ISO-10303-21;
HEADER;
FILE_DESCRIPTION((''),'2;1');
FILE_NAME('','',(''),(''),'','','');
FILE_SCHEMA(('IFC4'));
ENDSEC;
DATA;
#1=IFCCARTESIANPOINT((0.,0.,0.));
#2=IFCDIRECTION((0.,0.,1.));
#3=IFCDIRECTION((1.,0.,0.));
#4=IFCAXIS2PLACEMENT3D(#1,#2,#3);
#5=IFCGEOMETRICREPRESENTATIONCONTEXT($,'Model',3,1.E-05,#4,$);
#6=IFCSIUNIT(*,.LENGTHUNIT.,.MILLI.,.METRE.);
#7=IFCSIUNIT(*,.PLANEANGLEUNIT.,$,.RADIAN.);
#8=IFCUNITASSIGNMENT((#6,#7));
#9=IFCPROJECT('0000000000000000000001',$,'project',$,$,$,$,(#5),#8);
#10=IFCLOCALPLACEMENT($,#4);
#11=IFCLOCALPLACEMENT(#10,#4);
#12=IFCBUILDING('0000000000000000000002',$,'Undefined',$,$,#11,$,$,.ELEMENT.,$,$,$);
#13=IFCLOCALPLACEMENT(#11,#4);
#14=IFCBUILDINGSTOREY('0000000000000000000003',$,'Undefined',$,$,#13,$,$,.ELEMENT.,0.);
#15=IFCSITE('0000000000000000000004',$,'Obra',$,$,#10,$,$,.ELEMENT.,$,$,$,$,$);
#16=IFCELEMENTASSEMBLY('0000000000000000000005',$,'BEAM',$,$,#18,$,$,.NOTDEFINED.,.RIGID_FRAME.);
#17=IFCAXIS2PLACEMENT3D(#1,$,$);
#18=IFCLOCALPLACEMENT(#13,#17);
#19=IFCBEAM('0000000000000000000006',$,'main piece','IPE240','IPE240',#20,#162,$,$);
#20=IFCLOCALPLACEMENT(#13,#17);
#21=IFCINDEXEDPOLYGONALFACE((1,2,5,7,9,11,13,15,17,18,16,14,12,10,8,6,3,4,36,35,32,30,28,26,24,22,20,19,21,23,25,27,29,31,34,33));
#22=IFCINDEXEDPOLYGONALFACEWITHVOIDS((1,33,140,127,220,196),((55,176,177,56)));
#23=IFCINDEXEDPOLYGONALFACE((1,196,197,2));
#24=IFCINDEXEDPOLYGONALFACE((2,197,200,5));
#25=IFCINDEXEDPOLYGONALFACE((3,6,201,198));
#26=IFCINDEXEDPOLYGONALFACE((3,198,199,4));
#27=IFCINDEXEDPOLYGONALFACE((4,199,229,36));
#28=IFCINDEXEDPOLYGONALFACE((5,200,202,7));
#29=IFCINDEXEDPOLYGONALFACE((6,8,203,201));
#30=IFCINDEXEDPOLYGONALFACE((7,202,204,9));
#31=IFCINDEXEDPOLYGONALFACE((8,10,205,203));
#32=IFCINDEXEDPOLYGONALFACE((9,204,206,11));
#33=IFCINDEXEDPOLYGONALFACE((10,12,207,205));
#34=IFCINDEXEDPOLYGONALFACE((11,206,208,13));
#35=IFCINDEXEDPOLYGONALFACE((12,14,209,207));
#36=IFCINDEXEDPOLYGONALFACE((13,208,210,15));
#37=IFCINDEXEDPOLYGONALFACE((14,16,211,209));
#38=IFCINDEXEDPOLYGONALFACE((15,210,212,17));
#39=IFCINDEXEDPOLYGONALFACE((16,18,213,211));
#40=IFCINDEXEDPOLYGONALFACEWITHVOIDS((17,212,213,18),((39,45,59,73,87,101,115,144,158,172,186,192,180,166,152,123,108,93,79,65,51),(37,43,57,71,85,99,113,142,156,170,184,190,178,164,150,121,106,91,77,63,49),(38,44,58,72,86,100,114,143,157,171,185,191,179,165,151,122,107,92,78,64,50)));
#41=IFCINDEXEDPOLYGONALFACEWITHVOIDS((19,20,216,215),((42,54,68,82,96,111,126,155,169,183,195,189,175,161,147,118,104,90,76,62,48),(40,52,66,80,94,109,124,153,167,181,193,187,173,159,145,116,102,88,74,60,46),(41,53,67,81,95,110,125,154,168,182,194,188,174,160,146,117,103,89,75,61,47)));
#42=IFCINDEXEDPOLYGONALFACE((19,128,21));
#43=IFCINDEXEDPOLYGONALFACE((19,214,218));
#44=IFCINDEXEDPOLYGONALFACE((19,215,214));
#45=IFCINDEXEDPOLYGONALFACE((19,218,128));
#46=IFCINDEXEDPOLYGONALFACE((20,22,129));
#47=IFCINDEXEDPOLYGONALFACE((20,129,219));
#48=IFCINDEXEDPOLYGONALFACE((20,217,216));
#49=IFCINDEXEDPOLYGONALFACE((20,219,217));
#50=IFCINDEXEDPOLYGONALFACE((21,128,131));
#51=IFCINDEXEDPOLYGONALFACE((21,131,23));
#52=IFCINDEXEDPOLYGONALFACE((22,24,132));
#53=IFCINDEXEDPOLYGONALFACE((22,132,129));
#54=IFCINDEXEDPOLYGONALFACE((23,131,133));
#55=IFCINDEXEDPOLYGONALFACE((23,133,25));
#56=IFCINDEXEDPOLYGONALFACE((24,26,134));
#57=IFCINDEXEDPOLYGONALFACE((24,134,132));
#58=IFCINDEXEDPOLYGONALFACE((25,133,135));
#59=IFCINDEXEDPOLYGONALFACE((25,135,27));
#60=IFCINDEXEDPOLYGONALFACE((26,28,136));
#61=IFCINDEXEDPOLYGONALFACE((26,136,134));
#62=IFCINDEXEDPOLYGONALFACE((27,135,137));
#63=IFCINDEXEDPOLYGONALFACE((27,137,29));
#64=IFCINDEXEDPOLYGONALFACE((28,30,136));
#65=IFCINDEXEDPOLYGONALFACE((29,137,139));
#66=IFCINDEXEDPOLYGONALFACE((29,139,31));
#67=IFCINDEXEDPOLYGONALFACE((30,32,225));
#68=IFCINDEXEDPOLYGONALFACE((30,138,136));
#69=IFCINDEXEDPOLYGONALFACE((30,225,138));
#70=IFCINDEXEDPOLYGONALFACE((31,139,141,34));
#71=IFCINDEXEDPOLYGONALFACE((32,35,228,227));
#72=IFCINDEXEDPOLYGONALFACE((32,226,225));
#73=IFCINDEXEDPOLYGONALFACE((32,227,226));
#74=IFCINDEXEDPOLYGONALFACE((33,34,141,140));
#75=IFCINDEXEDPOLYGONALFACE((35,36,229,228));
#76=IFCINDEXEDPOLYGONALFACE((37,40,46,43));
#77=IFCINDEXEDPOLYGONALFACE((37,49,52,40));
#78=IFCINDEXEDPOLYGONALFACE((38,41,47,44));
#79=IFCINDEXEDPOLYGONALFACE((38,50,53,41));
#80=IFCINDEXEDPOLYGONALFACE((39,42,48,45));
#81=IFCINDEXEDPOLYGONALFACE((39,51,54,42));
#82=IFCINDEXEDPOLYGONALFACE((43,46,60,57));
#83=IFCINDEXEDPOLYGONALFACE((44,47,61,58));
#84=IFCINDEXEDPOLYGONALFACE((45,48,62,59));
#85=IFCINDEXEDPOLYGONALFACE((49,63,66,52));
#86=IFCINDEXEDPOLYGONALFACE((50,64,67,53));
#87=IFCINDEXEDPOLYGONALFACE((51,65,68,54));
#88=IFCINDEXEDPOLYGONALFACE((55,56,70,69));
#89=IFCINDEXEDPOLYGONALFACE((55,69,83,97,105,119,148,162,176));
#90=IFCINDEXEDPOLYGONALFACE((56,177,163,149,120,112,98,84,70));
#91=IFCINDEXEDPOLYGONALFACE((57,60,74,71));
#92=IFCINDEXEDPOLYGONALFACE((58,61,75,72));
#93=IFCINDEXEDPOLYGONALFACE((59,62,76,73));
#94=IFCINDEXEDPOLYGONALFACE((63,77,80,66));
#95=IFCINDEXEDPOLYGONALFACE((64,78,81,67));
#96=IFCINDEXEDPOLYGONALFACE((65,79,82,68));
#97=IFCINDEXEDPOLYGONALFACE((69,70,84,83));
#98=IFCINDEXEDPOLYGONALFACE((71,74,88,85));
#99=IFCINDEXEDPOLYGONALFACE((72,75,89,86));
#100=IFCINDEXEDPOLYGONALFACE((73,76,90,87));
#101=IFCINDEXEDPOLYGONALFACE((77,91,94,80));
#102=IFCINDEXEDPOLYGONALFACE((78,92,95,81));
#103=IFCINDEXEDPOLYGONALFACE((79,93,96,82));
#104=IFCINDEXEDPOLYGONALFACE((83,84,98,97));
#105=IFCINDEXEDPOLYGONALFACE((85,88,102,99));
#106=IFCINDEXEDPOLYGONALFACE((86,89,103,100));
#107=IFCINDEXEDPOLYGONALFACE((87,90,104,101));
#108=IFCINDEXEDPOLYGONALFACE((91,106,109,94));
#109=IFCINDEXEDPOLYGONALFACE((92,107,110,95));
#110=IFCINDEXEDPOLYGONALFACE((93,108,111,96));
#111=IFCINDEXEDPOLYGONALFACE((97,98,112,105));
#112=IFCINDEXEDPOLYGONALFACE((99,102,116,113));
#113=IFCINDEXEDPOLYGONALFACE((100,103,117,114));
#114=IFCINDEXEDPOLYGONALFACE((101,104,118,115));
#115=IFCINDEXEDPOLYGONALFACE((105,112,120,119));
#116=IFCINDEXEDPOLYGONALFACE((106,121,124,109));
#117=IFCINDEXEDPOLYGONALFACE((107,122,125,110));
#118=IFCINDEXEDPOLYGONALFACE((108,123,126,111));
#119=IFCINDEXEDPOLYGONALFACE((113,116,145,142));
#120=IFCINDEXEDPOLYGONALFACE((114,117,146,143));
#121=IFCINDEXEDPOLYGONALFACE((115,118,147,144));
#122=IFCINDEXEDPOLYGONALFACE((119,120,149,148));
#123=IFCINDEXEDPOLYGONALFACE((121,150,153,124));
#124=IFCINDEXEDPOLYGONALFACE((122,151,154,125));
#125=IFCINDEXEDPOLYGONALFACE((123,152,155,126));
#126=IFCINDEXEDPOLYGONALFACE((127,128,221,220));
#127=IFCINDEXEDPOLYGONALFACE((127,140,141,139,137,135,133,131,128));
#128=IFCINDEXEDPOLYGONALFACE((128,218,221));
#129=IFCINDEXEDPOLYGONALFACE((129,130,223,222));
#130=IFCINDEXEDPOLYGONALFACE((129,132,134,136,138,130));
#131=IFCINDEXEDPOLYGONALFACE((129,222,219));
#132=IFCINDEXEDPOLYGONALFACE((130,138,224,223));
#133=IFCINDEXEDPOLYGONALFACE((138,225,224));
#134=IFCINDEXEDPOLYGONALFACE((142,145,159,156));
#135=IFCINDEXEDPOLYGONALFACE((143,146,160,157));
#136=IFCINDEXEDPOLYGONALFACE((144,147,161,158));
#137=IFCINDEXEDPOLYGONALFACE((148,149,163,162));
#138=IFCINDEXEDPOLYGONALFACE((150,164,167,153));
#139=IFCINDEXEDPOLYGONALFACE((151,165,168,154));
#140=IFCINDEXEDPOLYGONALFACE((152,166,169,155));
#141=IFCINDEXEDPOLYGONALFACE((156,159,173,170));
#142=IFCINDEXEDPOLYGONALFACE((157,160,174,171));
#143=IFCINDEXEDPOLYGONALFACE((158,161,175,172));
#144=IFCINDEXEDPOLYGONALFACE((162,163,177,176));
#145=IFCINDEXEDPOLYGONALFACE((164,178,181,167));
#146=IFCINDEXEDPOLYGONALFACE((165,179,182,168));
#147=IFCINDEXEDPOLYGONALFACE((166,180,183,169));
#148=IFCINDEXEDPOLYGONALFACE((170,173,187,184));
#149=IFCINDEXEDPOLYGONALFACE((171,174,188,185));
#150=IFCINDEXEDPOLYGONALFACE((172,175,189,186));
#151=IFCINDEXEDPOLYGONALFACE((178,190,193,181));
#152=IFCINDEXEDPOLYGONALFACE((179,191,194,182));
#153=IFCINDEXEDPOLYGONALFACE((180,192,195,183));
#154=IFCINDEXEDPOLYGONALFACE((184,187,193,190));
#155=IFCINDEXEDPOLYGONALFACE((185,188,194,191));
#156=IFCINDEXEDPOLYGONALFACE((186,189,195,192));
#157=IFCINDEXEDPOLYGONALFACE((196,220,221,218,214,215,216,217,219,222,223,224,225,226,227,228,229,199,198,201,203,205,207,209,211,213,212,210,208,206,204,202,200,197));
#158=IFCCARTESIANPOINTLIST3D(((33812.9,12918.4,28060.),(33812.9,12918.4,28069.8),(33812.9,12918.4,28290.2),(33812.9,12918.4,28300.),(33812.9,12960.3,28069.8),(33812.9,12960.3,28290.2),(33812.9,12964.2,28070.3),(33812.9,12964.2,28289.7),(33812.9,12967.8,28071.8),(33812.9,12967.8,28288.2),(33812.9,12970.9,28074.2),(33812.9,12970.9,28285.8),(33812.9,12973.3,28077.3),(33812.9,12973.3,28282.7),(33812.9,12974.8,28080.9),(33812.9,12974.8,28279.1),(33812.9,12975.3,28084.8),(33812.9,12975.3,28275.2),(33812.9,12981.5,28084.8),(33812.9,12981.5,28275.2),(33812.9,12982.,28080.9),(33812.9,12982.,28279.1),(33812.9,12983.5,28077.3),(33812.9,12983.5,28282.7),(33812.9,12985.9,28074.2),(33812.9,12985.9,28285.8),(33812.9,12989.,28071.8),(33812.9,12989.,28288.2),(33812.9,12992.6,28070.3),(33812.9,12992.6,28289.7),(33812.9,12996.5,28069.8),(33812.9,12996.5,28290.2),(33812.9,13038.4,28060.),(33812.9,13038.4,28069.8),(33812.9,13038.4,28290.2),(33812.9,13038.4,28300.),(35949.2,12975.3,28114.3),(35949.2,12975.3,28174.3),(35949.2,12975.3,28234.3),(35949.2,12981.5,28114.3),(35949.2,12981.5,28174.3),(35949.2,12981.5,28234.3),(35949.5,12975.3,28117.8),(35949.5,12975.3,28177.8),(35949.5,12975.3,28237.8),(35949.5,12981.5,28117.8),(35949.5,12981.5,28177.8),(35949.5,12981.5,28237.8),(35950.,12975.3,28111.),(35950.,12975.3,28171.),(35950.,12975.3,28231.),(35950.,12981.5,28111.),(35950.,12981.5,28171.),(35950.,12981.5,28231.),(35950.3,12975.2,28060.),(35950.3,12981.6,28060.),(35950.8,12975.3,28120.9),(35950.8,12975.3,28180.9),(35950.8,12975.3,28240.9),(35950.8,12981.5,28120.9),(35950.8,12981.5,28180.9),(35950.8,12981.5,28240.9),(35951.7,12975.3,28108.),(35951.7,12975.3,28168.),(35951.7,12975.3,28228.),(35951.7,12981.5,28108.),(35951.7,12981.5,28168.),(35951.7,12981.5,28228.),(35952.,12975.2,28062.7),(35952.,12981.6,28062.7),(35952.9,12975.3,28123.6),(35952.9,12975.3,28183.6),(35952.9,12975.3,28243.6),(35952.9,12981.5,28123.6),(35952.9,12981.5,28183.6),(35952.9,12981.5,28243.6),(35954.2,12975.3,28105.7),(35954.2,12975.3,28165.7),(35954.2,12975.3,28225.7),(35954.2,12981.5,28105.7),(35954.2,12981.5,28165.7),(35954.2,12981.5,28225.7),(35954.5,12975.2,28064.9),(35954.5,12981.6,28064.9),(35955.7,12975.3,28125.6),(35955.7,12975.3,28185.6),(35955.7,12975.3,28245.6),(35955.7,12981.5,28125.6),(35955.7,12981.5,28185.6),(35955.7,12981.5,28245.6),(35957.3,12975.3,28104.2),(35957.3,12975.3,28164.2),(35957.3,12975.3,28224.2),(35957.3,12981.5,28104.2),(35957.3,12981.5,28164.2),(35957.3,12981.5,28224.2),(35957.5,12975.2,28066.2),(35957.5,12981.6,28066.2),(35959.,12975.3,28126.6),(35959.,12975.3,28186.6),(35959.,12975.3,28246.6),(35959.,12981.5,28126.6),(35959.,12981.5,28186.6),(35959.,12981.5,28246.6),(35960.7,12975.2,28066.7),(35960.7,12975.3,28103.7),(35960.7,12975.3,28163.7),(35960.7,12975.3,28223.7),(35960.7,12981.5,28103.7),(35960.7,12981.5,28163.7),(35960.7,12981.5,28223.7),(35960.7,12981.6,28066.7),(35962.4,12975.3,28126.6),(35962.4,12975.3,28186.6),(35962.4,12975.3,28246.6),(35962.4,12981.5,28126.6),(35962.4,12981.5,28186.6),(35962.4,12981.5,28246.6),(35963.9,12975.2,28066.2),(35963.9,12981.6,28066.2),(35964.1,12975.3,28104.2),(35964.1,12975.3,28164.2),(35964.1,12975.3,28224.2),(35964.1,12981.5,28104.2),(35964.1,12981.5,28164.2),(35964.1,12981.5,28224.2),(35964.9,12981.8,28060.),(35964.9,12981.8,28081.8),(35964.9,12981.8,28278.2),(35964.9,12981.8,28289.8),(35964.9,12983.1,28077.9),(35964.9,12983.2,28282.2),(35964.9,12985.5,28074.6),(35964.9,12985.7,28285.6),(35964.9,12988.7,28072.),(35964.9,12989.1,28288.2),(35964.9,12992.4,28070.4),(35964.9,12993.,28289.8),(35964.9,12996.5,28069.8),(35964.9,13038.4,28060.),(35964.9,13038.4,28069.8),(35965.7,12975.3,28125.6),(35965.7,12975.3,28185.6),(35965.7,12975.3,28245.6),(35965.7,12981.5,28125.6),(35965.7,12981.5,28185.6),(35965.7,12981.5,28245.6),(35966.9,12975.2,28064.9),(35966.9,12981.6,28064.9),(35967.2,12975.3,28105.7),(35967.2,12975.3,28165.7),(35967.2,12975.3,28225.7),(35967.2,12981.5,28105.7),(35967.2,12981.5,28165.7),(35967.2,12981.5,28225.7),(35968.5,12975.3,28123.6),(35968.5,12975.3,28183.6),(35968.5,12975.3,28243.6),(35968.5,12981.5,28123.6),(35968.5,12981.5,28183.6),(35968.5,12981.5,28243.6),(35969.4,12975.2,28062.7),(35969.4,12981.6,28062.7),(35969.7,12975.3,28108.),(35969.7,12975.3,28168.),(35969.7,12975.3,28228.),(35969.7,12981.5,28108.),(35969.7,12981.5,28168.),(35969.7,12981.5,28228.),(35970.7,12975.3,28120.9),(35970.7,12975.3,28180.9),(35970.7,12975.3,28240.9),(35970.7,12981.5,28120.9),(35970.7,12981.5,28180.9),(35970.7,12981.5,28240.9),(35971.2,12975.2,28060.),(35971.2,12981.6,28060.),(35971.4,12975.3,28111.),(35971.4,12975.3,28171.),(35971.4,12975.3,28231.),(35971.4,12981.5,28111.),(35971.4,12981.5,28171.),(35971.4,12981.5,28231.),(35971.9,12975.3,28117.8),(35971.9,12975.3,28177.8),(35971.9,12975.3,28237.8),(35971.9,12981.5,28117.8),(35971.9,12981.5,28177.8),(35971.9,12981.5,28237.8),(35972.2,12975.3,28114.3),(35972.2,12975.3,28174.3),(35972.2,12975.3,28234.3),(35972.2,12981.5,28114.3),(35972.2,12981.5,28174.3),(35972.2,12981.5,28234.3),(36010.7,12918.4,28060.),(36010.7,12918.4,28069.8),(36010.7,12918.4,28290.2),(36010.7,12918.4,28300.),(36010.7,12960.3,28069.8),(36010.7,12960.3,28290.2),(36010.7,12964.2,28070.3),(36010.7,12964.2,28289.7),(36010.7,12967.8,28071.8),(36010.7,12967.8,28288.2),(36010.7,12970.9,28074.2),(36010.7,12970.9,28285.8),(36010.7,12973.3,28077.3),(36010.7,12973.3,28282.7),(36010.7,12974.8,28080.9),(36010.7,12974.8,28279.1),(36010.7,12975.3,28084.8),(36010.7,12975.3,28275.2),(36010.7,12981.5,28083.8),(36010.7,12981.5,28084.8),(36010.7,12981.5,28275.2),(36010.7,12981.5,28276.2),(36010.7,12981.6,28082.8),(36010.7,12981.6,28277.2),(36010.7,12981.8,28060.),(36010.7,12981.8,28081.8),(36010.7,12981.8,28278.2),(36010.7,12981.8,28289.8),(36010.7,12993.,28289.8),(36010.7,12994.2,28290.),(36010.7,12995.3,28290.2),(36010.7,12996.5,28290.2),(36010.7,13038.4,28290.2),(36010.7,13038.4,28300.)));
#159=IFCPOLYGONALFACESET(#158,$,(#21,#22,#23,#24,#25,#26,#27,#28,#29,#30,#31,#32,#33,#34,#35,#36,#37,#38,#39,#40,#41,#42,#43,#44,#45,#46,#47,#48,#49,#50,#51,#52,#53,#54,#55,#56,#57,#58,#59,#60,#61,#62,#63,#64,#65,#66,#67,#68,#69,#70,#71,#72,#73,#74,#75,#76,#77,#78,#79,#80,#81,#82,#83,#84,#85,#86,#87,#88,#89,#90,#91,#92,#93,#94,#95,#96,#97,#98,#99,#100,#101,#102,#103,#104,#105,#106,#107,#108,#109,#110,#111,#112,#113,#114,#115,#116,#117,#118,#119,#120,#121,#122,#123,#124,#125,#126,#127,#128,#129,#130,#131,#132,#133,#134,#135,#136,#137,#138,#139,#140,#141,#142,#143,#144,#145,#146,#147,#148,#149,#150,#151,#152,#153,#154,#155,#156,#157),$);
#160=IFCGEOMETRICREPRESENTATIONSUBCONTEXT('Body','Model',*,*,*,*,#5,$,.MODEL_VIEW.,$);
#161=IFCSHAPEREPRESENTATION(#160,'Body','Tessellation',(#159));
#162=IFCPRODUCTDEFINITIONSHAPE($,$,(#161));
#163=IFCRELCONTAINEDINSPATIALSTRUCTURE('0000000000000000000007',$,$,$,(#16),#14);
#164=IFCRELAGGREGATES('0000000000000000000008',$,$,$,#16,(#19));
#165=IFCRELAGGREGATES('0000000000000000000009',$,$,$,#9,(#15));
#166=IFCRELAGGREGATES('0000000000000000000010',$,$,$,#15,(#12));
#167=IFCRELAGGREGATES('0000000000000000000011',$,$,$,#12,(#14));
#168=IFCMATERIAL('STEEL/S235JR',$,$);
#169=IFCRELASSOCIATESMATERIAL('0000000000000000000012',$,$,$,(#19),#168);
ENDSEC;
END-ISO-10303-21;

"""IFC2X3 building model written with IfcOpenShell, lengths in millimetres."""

from ifc_helpers import new_model, si_unit, frame, origin_with_axes, origin_2d_with_axis, place, context, subcontext, project, spatial, rectangle, circle, i_section, extrude, clip, halfspace, source, transform, mapped, material, element, aggregate, save


model = new_model("IFC2X3")

# Units and contexts
model_context = context("Model", 3, precision=1e-05, world=origin_with_axes())
body_context = subcontext(model_context, "Body", "Model", "MODEL_VIEW")
ifc_project = project(units=[si_unit("LENGTHUNIT", "METRE", prefix="MILLI"), si_unit("PLANEANGLEUNIT", "RADIAN")], contexts=[model_context])

# Site, building, storey
site_placement = place(None, origin_with_axes())
site = spatial("IfcSite", under=ifc_project, at=site_placement, Name="Obra", CompositionType="ELEMENT")
building_placement = place(site_placement, origin_with_axes())
building = spatial("IfcBuilding", under=site, at=building_placement, Name="Undefined", CompositionType="ELEMENT")
storey_placement = place(building_placement, origin_with_axes())
storey = spatial("IfcBuildingStorey", under=building, at=storey_placement, Name="Undefined", CompositionType="ELEMENT", Elevation=0.0)

# Element assembly, beam, openings
ifc_material_1 = material(Name="STEEL/S235JR")
shared_shape_1 = source(origin_with_axes(), body_context, "Body", "SweptSolid", [
    extrude(circle(Radius=11.5, at=origin_2d_with_axis()), frame((0.0, -3.2, 0.0), z_axis=(0.0, 1.0, 0.0), x_axis=(1.0, 0.0, 0.0)), (0.0, 0.0, 1.0), 6.4),
])
assembly_1_placement = place(storey_placement, origin_with_axes())
assembly_1 = element("IfcElementAssembly", 1, at=assembly_1_placement, inside=storey, Name="BEAM", AssemblyPlace="NOTDEFINED", PredefinedType="RIGID_FRAME")
beam_1_placement = place(assembly_1_placement, frame((33812.9, 12978.4, 28180.0), z_axis=(0.0, 0.0, 1.0), x_axis=(1.0, 0.0, 0.0)))
beam_1 = element("IfcBeam", 2, at=beam_1_placement, material=ifc_material_1, Name="main piece", Description="IPE240", ObjectType="IPE240", context=body_context, shape_type="Clipping", body=[
    clip(extrude(i_section(OverallWidth=120.0, OverallDepth=240.0, WebThickness=6.2, FlangeThickness=9.8, FilletRadius=15.0, at=origin_2d_with_axis()), frame((2197.8, 0.0, 0.0), z_axis=(-1.0, 0.0, 0.0), x_axis=(0.0, -1.0, 0.0)), (0.0, 0.0, 1.0), 2197.8), halfspace(frame((2197.8, 0.0, -220.0), z_axis=(-1.0, 0.0, 0.0), x_axis=(0.0, 1.0, 0.0)), True)),
])
opening_1_placement = place(assembly_1_placement, frame((33812.9, 12978.4, 28180.0), z_axis=(0.0, 0.0, 1.0), x_axis=(1.0, 0.0, 0.0)))
element("IfcOpeningElement", 3, at=opening_1_placement, cuts=beam_1, ObjectType="Recess", context=body_context, shape_type="SweptSolid", body=[
    extrude(rectangle(XDim=26.2, YDim=76.2, at=origin_2d_with_axis()), frame((2235.9, 61.0, 107.9), z_axis=(0.0, -1.0, 0.0), x_axis=(0.0, 0.0, -1.0)), (0.0, 0.0, 1.0), 122.0),
])
opening_2_placement = place(assembly_1_placement, frame((33812.9, 12978.4, 28180.0), z_axis=(0.0, 0.0, 1.0), x_axis=(1.0, 0.0, 0.0)))
element("IfcOpeningElement", 4, at=opening_2_placement, cuts=beam_1, ObjectType="Recess", context=body_context, shape_type="SweptSolid", body=[
    extrude(rectangle(XDim=120.0, YDim=174.2, at=origin_2d_with_axis()), frame((2212.0, 90.5, 109.8), z_axis=(0.0, 0.0, -1.0), x_axis=(-1.0, 0.0, 0.0)), (0.0, 0.0, 1.0), 249.6),
])
opening_3_placement = place(assembly_1_placement, frame((36010.7, 12978.4, 28275.2), z_axis=(-1.0, 0.0, 0.0), x_axis=(0.0, 0.0, -1.0)))
element("IfcOpeningElement", 5, at=opening_3_placement, cuts=beam_1, ObjectType="Opening", context=body_context, shape_type="MappedRepresentation", body=[
    mapped(shared_shape_1, transform((40.0, 0.0, 50.0))),
    mapped(shared_shape_1, transform((100.0, 0.0, 50.0))),
    mapped(shared_shape_1, transform((160.0, 0.0, 50.0))),
    mapped(shared_shape_1, transform((220.0, 0.0, 50.0))),
])
aggregate(assembly_1, [beam_1])

save(model, "model.ifc")
